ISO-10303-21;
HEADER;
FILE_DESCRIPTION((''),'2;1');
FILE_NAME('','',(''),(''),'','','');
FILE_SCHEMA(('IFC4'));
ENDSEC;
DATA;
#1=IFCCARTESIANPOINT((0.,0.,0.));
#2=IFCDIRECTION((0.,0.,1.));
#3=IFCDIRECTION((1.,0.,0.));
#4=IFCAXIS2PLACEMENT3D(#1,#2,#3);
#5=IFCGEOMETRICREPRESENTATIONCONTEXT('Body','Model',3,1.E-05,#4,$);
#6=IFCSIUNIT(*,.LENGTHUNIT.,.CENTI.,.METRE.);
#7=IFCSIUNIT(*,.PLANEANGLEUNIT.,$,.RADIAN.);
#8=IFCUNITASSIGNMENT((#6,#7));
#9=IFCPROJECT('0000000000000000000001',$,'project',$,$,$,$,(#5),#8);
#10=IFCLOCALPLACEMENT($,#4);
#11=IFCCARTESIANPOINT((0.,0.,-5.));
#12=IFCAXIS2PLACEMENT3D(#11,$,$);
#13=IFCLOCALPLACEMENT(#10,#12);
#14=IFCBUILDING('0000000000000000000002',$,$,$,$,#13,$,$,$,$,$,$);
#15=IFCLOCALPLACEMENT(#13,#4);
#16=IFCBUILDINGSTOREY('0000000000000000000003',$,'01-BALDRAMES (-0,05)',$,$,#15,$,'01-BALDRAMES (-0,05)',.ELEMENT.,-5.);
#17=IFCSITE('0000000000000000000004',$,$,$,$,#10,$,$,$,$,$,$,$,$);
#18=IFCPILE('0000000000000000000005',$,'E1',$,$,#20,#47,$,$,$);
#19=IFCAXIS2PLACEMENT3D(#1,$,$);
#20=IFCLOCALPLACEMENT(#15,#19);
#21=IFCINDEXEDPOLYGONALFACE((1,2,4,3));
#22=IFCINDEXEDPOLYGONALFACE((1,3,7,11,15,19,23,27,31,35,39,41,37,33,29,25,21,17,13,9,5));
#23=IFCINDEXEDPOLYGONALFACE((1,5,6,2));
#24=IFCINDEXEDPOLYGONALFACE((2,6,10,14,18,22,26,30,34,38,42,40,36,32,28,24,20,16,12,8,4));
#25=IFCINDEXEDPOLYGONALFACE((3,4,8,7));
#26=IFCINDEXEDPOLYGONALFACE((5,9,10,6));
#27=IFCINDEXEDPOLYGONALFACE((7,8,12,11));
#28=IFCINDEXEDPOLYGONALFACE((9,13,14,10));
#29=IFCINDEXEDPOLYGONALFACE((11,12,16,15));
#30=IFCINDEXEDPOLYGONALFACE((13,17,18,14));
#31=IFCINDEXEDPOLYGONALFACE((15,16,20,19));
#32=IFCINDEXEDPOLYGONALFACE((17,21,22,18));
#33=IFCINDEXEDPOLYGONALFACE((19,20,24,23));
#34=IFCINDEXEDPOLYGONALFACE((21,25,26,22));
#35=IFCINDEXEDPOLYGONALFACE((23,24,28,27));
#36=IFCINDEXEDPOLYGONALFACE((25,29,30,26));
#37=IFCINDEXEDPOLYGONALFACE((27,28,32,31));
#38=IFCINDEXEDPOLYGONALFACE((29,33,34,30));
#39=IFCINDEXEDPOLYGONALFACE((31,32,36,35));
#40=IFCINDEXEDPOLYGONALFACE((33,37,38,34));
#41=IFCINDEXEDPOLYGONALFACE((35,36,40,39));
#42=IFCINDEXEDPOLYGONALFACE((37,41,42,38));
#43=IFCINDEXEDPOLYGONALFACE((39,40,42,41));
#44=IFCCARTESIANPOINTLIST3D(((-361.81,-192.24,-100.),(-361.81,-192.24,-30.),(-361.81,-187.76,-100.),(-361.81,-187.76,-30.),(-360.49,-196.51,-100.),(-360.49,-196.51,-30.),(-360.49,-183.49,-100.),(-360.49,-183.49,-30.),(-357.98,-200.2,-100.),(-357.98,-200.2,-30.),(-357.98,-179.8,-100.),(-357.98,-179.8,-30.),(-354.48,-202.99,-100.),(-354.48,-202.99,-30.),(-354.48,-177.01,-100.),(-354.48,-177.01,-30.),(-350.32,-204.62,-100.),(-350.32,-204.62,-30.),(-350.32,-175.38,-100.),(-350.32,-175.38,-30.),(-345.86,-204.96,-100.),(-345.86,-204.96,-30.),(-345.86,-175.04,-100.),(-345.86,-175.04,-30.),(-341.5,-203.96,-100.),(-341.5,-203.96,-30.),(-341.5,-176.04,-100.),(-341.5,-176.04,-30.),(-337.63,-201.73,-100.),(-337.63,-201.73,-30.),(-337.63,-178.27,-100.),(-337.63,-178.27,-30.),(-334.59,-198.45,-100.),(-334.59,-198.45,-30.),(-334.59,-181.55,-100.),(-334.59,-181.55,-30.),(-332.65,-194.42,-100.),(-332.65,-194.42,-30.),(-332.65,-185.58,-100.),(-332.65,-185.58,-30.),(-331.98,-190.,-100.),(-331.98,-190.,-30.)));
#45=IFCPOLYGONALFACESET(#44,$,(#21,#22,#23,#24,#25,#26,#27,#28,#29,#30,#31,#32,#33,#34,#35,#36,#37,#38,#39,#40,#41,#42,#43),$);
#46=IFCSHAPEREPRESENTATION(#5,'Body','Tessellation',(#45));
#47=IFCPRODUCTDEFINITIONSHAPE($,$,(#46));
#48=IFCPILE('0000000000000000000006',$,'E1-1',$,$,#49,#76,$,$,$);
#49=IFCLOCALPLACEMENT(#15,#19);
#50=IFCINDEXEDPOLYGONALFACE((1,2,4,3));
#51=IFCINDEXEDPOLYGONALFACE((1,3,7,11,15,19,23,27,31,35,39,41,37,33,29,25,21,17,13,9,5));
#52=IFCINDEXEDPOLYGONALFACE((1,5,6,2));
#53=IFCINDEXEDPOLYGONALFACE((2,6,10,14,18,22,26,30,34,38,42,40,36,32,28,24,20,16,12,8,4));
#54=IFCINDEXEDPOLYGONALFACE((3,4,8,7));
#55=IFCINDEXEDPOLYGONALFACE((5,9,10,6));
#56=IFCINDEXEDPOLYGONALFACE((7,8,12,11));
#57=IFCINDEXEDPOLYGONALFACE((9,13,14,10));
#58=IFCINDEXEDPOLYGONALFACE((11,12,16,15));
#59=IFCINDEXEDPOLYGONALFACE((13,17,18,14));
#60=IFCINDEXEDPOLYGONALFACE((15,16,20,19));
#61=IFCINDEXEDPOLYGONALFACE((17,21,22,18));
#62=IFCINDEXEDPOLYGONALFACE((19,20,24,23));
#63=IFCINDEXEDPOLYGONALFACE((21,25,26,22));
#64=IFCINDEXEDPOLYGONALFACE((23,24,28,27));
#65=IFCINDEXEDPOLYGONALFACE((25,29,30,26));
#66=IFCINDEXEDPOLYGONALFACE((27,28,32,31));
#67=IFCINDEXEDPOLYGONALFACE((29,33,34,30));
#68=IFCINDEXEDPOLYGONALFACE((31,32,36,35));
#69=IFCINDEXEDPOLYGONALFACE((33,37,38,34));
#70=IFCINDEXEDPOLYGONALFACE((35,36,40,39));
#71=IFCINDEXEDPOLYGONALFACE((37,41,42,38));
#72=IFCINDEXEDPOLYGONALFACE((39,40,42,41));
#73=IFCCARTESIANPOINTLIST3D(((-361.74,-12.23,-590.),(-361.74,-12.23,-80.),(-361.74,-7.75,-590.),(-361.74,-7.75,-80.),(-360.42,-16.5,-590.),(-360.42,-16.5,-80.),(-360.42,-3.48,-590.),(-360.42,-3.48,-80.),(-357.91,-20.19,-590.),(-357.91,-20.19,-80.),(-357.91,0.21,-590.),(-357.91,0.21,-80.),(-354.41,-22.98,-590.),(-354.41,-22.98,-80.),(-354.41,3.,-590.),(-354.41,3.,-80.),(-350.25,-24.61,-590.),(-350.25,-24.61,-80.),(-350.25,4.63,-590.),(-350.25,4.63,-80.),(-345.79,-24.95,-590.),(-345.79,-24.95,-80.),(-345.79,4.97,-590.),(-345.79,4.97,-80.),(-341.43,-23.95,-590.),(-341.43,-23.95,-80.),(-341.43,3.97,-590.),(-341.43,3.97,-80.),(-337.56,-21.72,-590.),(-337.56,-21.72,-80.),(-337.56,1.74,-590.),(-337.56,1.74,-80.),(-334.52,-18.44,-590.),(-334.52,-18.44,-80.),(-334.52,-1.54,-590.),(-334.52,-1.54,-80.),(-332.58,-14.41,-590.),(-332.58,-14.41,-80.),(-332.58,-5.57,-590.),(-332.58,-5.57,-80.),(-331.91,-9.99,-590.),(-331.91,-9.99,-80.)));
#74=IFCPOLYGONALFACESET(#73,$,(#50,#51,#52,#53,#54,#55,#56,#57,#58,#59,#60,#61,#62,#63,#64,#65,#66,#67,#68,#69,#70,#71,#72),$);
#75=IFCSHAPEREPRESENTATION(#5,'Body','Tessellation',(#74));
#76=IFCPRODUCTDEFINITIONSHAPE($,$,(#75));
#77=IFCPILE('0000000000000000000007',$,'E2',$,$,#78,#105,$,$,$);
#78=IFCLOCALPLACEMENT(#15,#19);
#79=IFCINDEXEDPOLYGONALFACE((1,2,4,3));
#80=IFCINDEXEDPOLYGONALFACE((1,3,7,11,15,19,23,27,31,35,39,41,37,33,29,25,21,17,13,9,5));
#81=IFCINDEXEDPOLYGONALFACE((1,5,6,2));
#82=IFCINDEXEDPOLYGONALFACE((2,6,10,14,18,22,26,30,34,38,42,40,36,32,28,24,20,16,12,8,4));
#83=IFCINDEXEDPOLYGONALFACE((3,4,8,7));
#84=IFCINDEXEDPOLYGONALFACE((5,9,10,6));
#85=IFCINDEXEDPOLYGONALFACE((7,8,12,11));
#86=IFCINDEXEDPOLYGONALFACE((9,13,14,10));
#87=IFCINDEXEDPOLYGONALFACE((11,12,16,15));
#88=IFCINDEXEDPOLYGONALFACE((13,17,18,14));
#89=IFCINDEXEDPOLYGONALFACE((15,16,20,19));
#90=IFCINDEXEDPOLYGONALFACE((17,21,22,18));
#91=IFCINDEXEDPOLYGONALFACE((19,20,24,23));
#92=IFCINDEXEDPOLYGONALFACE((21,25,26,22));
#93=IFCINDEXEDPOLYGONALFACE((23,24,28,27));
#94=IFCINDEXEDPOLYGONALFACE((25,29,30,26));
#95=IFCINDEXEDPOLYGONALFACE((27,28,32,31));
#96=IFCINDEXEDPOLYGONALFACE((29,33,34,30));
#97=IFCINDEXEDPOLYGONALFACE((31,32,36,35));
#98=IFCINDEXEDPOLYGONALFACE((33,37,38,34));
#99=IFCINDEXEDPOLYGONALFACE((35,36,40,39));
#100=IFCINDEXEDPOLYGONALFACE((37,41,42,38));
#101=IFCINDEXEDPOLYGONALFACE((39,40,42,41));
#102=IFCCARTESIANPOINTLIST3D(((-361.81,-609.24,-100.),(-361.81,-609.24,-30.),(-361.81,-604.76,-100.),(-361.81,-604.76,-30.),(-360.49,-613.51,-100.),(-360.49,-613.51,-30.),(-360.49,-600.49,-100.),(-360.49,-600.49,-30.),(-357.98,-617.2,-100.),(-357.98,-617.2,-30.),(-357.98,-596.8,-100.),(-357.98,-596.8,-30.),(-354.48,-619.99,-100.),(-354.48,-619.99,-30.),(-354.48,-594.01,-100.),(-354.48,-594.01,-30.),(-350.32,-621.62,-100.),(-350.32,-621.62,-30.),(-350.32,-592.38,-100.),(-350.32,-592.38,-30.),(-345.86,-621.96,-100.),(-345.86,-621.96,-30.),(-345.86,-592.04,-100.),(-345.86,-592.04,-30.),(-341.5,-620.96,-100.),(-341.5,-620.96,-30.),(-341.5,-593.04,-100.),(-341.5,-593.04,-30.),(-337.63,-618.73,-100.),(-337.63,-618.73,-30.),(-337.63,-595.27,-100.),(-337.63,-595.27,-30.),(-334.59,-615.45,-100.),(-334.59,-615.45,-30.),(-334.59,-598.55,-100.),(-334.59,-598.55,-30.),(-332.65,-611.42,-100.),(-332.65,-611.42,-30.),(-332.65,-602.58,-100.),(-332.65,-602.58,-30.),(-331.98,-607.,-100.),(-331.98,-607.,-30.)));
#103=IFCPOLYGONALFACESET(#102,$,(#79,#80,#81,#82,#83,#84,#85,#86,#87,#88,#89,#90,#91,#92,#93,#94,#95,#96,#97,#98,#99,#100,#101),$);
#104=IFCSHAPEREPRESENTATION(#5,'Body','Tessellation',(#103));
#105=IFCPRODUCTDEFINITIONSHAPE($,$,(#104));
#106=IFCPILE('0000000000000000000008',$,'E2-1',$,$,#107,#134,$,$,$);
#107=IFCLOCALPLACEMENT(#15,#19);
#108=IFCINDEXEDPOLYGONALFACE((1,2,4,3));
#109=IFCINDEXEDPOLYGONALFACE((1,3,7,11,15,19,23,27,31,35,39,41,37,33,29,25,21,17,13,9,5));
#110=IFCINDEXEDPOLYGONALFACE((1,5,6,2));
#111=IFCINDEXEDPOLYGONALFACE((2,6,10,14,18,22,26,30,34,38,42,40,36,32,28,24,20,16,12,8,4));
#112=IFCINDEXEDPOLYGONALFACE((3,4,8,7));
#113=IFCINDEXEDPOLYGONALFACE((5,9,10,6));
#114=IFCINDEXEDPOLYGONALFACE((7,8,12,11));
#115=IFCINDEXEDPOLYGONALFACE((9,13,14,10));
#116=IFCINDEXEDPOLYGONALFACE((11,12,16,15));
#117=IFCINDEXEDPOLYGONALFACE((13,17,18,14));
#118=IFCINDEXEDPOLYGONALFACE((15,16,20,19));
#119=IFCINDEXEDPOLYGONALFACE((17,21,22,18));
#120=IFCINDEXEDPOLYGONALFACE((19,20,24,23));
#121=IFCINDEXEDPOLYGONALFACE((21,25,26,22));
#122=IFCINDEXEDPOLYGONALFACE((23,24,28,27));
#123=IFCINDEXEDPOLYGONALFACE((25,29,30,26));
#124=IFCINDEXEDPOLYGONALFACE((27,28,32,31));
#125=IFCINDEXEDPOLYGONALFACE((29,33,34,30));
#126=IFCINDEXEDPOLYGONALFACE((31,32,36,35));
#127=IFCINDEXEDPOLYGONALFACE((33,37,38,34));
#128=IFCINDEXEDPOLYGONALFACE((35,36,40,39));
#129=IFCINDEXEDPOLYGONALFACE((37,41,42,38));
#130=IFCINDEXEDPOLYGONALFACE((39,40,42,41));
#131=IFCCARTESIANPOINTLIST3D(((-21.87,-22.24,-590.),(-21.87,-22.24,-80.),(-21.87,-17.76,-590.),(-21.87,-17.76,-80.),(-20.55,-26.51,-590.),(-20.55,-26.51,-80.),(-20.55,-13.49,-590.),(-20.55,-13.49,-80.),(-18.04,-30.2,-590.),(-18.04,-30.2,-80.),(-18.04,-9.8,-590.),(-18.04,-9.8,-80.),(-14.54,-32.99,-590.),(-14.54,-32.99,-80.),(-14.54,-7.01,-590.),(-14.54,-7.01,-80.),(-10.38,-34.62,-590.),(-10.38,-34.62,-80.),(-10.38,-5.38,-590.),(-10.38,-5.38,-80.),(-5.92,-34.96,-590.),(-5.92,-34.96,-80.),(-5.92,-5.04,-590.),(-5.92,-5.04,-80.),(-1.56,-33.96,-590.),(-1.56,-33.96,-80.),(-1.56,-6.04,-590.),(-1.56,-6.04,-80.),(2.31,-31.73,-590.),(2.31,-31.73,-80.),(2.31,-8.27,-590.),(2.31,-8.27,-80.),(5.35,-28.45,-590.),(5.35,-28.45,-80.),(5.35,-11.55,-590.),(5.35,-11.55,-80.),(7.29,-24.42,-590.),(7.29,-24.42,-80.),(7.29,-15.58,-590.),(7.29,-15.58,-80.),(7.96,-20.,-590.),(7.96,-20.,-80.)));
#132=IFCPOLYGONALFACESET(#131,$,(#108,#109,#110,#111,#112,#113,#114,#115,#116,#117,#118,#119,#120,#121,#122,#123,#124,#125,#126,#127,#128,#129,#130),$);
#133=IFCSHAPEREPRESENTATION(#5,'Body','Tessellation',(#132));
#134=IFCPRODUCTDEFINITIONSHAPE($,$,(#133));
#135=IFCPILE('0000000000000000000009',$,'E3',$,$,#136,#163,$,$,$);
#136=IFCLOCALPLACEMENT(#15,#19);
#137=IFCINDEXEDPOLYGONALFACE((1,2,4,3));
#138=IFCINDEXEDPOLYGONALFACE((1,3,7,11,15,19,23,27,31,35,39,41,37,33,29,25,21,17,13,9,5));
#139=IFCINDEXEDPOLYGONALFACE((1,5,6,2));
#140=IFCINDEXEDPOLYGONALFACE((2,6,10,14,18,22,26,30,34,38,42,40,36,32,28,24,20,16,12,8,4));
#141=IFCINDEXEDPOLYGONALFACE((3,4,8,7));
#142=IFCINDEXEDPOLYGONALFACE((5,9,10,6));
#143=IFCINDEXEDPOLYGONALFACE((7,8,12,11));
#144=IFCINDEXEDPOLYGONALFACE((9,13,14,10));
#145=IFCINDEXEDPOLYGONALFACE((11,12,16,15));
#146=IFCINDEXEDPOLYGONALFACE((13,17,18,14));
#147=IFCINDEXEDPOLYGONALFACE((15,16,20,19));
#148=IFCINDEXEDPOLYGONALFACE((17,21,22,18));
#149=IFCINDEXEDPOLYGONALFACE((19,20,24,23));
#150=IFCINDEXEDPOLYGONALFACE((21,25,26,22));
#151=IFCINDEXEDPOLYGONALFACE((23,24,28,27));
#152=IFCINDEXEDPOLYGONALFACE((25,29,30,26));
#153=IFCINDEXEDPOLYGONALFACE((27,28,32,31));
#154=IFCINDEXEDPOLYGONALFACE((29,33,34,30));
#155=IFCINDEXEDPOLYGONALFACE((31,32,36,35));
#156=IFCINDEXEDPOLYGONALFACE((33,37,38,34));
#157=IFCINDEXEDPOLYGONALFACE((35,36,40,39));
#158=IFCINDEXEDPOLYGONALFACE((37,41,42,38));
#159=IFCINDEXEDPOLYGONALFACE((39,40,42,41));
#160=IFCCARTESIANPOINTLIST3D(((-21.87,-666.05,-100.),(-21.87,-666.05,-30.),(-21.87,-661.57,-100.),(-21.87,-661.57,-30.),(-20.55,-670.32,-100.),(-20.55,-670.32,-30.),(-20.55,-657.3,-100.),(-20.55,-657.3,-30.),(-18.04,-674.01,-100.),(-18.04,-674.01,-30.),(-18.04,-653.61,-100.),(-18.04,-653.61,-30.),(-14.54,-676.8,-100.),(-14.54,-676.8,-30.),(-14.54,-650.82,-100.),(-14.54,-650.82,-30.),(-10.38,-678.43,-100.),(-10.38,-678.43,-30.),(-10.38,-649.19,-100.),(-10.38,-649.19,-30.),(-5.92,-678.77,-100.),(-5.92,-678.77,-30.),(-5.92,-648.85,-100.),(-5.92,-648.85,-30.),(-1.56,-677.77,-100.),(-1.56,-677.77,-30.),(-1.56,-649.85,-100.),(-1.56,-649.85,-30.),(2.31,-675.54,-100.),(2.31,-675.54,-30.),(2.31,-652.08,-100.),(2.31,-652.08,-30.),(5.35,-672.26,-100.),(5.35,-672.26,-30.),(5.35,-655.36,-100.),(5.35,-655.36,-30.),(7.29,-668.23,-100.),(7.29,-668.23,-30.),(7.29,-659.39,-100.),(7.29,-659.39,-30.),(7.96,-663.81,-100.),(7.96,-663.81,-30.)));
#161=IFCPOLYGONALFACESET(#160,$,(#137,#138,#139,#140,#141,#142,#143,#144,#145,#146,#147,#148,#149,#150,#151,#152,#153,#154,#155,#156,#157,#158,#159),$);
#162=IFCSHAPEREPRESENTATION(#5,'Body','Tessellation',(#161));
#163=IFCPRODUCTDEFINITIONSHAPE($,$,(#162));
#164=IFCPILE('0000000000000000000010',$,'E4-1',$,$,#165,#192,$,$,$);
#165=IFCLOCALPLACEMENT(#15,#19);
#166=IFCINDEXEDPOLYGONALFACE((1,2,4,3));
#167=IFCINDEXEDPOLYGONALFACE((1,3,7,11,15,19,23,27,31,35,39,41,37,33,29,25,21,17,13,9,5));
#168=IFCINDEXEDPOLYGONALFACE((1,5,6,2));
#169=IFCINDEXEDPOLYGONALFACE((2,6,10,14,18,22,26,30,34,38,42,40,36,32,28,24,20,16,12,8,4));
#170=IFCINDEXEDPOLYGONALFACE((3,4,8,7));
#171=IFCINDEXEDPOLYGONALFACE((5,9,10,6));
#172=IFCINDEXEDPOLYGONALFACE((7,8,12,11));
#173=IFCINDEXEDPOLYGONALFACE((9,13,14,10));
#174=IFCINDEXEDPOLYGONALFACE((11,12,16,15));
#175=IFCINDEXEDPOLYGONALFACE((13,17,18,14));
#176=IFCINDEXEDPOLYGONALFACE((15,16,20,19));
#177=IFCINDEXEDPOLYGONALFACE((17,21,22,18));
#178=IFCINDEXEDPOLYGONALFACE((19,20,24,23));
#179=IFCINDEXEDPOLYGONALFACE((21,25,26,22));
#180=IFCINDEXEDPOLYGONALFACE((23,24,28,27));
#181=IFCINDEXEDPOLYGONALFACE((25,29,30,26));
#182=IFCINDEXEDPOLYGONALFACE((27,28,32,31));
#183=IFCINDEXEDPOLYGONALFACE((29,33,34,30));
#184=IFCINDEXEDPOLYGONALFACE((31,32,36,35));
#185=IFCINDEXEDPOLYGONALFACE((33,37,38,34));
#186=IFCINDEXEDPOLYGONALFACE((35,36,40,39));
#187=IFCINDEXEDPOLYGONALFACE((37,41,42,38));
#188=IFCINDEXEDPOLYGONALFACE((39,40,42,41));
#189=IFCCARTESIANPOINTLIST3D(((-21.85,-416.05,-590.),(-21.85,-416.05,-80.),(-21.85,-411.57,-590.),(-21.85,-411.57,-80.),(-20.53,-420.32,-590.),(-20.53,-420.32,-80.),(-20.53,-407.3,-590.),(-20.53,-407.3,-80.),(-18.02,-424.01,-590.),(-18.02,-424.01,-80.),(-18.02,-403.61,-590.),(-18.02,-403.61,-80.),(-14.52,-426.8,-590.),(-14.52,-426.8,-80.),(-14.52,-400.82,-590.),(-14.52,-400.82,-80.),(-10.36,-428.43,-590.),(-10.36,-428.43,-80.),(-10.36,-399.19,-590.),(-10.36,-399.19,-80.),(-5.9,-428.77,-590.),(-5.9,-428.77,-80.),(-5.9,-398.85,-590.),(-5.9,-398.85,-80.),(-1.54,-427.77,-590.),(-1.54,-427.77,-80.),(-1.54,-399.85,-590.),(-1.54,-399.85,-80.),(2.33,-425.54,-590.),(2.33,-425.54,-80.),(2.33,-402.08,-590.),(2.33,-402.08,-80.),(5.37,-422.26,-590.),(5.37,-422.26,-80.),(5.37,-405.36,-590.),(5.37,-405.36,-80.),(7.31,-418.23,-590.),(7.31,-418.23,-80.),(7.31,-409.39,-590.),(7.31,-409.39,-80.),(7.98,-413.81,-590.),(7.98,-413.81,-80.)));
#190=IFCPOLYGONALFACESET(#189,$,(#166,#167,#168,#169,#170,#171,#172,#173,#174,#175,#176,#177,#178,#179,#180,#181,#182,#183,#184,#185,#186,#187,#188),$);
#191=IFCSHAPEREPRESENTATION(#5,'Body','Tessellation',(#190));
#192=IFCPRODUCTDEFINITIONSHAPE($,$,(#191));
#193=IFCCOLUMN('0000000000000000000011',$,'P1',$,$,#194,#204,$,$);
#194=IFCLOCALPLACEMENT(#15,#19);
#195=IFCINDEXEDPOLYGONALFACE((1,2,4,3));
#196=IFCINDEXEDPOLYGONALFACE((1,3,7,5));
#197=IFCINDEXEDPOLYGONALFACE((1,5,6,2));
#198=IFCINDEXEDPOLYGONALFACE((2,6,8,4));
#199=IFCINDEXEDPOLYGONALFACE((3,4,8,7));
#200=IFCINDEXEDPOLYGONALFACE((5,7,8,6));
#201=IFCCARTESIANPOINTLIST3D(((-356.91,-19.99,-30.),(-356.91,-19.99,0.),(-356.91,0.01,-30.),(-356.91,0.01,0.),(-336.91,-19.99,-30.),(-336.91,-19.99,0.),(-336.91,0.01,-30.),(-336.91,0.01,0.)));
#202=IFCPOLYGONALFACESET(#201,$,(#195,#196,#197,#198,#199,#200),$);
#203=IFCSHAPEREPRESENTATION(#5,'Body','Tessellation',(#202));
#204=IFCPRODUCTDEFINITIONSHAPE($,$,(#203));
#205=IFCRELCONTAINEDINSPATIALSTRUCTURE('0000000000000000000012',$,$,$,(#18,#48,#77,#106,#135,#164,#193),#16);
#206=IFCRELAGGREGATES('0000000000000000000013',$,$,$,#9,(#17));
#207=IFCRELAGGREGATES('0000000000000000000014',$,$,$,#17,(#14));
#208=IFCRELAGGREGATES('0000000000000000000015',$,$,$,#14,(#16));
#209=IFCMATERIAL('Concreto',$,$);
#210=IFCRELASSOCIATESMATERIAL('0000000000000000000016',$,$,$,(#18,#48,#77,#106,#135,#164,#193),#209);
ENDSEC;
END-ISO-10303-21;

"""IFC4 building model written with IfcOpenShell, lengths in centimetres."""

from ifc_helpers import new_model, si_unit, frame, origin_with_axes, origin_2d_with_axis, place, context, project, spatial, rectangle, circle, extrude, material, element, save


model = new_model("IFC4")

# Units and contexts
model_context = context("Model", 3, precision=1e-05, world=origin_with_axes(), identifier="Body")
ifc_project = project(units=[si_unit("LENGTHUNIT", "METRE", prefix="CENTI"), si_unit("PLANEANGLEUNIT", "RADIAN")], contexts=[model_context])

# Site, building, storey
site_placement = place(None, origin_with_axes())
site = spatial("IfcSite", under=ifc_project, at=site_placement)
building_placement = place(site_placement, frame((0.0, 0.0, -5.0)))
building = spatial("IfcBuilding", under=site, at=building_placement)
storey_placement = place(building_placement, origin_with_axes())
storey = spatial("IfcBuildingStorey", under=building, at=storey_placement, Name="01-BALDRAMES (-0,05)", LongName="01-BALDRAMES (-0,05)", CompositionType="ELEMENT", Elevation=-5.0)

# Piles
ifc_material = material(Name="Concreto")
pile_1_placement = place(storey_placement, frame((-346.98, -190.0, -30.0), z_axis=(0.0, 0.0, 1.0), x_axis=(1.0, 0.0, 0.0)))
element("IfcPile", 1, at=pile_1_placement, inside=storey, material=ifc_material, Name="E1", context=model_context, shape_type="SolidModel", body=[
    extrude(circle(Radius=15.0, at=origin_2d_with_axis()), frame((0.0, 0.0, -70.0), z_axis=(0.0, 0.0, 1.0), x_axis=(1.0, 0.0, 0.0)), (0.0, 0.0, 1.0), 70.0),
])
pile_2_placement = place(storey_placement, frame((-346.91, -9.99, -80.0), z_axis=(0.0, 0.0, 1.0), x_axis=(1.0, 0.0, 0.0)))
element("IfcPile", 2, at=pile_2_placement, inside=storey, material=ifc_material, Name="E1-1", context=model_context, shape_type="SweptSolid", body=[
    extrude(circle(Radius=15.0, at=origin_2d_with_axis()), frame((0.0, 0.0, -510.0), z_axis=(0.0, 0.0, 1.0), x_axis=(1.0, 0.0, 0.0)), (0.0, 0.0, 1.0), 510.0),
])
pile_3_placement = place(storey_placement, frame((-346.98, -607.0, -30.0), z_axis=(0.0, 0.0, 1.0), x_axis=(1.0, 0.0, 0.0)))
element("IfcPile", 3, at=pile_3_placement, inside=storey, material=ifc_material, Name="E2", context=model_context, shape_type="SolidModel", body=[
    extrude(circle(Radius=15.0, at=origin_2d_with_axis()), frame((0.0, 0.0, -70.0), z_axis=(0.0, 0.0, 1.0), x_axis=(1.0, 0.0, 0.0)), (0.0, 0.0, 1.0), 70.0),
])
pile_4_placement = place(storey_placement, frame((-7.04, -20.0, -80.0), z_axis=(0.0, 0.0, 1.0), x_axis=(1.0, 0.0, 0.0)))
element("IfcPile", 4, at=pile_4_placement, inside=storey, material=ifc_material, Name="E2-1", context=model_context, shape_type="SweptSolid", body=[
    extrude(circle(Radius=15.0, at=origin_2d_with_axis()), frame((0.0, 0.0, -510.0), z_axis=(0.0, 0.0, 1.0), x_axis=(1.0, 0.0, 0.0)), (0.0, 0.0, 1.0), 510.0),
])
pile_5_placement = place(storey_placement, frame((-7.04, -663.81, -30.0), z_axis=(0.0, 0.0, 1.0), x_axis=(1.0, 0.0, 0.0)))
element("IfcPile", 5, at=pile_5_placement, inside=storey, material=ifc_material, Name="E3", context=model_context, shape_type="SolidModel", body=[
    extrude(circle(Radius=15.0, at=origin_2d_with_axis()), frame((0.0, 0.0, -70.0), z_axis=(0.0, 0.0, 1.0), x_axis=(1.0, 0.0, 0.0)), (0.0, 0.0, 1.0), 70.0),
])
pile_6_placement = place(storey_placement, frame((-7.02, -413.81, -80.0), z_axis=(0.0, 0.0, 1.0), x_axis=(1.0, 0.0, 0.0)))
element("IfcPile", 6, at=pile_6_placement, inside=storey, material=ifc_material, Name="E4-1", context=model_context, shape_type="SweptSolid", body=[
    extrude(circle(Radius=15.0, at=origin_2d_with_axis()), frame((0.0, 0.0, -510.0), z_axis=(0.0, 0.0, 1.0), x_axis=(1.0, 0.0, 0.0)), (0.0, 0.0, 1.0), 510.0),
])

# Column
column_placement = place(storey_placement, frame((-346.91, -9.99, 0.0), z_axis=(0.0, 0.0, 1.0), x_axis=(1.0, 0.0, 0.0)))
element("IfcColumn", 7, at=column_placement, inside=storey, material=ifc_material, Name="P1", context=model_context, shape_type="SolidModel", body=[
    extrude(rectangle(XDim=20.0, YDim=20.0, at=origin_2d_with_axis()), frame((0.0, 0.0, 0.0), z_axis=(0.0, 0.0, 1.0), x_axis=(-1.0, 0.0, 0.0)), (0.0, 0.0, -1.0), 30.0),
])

save(model, "model.ifc")
